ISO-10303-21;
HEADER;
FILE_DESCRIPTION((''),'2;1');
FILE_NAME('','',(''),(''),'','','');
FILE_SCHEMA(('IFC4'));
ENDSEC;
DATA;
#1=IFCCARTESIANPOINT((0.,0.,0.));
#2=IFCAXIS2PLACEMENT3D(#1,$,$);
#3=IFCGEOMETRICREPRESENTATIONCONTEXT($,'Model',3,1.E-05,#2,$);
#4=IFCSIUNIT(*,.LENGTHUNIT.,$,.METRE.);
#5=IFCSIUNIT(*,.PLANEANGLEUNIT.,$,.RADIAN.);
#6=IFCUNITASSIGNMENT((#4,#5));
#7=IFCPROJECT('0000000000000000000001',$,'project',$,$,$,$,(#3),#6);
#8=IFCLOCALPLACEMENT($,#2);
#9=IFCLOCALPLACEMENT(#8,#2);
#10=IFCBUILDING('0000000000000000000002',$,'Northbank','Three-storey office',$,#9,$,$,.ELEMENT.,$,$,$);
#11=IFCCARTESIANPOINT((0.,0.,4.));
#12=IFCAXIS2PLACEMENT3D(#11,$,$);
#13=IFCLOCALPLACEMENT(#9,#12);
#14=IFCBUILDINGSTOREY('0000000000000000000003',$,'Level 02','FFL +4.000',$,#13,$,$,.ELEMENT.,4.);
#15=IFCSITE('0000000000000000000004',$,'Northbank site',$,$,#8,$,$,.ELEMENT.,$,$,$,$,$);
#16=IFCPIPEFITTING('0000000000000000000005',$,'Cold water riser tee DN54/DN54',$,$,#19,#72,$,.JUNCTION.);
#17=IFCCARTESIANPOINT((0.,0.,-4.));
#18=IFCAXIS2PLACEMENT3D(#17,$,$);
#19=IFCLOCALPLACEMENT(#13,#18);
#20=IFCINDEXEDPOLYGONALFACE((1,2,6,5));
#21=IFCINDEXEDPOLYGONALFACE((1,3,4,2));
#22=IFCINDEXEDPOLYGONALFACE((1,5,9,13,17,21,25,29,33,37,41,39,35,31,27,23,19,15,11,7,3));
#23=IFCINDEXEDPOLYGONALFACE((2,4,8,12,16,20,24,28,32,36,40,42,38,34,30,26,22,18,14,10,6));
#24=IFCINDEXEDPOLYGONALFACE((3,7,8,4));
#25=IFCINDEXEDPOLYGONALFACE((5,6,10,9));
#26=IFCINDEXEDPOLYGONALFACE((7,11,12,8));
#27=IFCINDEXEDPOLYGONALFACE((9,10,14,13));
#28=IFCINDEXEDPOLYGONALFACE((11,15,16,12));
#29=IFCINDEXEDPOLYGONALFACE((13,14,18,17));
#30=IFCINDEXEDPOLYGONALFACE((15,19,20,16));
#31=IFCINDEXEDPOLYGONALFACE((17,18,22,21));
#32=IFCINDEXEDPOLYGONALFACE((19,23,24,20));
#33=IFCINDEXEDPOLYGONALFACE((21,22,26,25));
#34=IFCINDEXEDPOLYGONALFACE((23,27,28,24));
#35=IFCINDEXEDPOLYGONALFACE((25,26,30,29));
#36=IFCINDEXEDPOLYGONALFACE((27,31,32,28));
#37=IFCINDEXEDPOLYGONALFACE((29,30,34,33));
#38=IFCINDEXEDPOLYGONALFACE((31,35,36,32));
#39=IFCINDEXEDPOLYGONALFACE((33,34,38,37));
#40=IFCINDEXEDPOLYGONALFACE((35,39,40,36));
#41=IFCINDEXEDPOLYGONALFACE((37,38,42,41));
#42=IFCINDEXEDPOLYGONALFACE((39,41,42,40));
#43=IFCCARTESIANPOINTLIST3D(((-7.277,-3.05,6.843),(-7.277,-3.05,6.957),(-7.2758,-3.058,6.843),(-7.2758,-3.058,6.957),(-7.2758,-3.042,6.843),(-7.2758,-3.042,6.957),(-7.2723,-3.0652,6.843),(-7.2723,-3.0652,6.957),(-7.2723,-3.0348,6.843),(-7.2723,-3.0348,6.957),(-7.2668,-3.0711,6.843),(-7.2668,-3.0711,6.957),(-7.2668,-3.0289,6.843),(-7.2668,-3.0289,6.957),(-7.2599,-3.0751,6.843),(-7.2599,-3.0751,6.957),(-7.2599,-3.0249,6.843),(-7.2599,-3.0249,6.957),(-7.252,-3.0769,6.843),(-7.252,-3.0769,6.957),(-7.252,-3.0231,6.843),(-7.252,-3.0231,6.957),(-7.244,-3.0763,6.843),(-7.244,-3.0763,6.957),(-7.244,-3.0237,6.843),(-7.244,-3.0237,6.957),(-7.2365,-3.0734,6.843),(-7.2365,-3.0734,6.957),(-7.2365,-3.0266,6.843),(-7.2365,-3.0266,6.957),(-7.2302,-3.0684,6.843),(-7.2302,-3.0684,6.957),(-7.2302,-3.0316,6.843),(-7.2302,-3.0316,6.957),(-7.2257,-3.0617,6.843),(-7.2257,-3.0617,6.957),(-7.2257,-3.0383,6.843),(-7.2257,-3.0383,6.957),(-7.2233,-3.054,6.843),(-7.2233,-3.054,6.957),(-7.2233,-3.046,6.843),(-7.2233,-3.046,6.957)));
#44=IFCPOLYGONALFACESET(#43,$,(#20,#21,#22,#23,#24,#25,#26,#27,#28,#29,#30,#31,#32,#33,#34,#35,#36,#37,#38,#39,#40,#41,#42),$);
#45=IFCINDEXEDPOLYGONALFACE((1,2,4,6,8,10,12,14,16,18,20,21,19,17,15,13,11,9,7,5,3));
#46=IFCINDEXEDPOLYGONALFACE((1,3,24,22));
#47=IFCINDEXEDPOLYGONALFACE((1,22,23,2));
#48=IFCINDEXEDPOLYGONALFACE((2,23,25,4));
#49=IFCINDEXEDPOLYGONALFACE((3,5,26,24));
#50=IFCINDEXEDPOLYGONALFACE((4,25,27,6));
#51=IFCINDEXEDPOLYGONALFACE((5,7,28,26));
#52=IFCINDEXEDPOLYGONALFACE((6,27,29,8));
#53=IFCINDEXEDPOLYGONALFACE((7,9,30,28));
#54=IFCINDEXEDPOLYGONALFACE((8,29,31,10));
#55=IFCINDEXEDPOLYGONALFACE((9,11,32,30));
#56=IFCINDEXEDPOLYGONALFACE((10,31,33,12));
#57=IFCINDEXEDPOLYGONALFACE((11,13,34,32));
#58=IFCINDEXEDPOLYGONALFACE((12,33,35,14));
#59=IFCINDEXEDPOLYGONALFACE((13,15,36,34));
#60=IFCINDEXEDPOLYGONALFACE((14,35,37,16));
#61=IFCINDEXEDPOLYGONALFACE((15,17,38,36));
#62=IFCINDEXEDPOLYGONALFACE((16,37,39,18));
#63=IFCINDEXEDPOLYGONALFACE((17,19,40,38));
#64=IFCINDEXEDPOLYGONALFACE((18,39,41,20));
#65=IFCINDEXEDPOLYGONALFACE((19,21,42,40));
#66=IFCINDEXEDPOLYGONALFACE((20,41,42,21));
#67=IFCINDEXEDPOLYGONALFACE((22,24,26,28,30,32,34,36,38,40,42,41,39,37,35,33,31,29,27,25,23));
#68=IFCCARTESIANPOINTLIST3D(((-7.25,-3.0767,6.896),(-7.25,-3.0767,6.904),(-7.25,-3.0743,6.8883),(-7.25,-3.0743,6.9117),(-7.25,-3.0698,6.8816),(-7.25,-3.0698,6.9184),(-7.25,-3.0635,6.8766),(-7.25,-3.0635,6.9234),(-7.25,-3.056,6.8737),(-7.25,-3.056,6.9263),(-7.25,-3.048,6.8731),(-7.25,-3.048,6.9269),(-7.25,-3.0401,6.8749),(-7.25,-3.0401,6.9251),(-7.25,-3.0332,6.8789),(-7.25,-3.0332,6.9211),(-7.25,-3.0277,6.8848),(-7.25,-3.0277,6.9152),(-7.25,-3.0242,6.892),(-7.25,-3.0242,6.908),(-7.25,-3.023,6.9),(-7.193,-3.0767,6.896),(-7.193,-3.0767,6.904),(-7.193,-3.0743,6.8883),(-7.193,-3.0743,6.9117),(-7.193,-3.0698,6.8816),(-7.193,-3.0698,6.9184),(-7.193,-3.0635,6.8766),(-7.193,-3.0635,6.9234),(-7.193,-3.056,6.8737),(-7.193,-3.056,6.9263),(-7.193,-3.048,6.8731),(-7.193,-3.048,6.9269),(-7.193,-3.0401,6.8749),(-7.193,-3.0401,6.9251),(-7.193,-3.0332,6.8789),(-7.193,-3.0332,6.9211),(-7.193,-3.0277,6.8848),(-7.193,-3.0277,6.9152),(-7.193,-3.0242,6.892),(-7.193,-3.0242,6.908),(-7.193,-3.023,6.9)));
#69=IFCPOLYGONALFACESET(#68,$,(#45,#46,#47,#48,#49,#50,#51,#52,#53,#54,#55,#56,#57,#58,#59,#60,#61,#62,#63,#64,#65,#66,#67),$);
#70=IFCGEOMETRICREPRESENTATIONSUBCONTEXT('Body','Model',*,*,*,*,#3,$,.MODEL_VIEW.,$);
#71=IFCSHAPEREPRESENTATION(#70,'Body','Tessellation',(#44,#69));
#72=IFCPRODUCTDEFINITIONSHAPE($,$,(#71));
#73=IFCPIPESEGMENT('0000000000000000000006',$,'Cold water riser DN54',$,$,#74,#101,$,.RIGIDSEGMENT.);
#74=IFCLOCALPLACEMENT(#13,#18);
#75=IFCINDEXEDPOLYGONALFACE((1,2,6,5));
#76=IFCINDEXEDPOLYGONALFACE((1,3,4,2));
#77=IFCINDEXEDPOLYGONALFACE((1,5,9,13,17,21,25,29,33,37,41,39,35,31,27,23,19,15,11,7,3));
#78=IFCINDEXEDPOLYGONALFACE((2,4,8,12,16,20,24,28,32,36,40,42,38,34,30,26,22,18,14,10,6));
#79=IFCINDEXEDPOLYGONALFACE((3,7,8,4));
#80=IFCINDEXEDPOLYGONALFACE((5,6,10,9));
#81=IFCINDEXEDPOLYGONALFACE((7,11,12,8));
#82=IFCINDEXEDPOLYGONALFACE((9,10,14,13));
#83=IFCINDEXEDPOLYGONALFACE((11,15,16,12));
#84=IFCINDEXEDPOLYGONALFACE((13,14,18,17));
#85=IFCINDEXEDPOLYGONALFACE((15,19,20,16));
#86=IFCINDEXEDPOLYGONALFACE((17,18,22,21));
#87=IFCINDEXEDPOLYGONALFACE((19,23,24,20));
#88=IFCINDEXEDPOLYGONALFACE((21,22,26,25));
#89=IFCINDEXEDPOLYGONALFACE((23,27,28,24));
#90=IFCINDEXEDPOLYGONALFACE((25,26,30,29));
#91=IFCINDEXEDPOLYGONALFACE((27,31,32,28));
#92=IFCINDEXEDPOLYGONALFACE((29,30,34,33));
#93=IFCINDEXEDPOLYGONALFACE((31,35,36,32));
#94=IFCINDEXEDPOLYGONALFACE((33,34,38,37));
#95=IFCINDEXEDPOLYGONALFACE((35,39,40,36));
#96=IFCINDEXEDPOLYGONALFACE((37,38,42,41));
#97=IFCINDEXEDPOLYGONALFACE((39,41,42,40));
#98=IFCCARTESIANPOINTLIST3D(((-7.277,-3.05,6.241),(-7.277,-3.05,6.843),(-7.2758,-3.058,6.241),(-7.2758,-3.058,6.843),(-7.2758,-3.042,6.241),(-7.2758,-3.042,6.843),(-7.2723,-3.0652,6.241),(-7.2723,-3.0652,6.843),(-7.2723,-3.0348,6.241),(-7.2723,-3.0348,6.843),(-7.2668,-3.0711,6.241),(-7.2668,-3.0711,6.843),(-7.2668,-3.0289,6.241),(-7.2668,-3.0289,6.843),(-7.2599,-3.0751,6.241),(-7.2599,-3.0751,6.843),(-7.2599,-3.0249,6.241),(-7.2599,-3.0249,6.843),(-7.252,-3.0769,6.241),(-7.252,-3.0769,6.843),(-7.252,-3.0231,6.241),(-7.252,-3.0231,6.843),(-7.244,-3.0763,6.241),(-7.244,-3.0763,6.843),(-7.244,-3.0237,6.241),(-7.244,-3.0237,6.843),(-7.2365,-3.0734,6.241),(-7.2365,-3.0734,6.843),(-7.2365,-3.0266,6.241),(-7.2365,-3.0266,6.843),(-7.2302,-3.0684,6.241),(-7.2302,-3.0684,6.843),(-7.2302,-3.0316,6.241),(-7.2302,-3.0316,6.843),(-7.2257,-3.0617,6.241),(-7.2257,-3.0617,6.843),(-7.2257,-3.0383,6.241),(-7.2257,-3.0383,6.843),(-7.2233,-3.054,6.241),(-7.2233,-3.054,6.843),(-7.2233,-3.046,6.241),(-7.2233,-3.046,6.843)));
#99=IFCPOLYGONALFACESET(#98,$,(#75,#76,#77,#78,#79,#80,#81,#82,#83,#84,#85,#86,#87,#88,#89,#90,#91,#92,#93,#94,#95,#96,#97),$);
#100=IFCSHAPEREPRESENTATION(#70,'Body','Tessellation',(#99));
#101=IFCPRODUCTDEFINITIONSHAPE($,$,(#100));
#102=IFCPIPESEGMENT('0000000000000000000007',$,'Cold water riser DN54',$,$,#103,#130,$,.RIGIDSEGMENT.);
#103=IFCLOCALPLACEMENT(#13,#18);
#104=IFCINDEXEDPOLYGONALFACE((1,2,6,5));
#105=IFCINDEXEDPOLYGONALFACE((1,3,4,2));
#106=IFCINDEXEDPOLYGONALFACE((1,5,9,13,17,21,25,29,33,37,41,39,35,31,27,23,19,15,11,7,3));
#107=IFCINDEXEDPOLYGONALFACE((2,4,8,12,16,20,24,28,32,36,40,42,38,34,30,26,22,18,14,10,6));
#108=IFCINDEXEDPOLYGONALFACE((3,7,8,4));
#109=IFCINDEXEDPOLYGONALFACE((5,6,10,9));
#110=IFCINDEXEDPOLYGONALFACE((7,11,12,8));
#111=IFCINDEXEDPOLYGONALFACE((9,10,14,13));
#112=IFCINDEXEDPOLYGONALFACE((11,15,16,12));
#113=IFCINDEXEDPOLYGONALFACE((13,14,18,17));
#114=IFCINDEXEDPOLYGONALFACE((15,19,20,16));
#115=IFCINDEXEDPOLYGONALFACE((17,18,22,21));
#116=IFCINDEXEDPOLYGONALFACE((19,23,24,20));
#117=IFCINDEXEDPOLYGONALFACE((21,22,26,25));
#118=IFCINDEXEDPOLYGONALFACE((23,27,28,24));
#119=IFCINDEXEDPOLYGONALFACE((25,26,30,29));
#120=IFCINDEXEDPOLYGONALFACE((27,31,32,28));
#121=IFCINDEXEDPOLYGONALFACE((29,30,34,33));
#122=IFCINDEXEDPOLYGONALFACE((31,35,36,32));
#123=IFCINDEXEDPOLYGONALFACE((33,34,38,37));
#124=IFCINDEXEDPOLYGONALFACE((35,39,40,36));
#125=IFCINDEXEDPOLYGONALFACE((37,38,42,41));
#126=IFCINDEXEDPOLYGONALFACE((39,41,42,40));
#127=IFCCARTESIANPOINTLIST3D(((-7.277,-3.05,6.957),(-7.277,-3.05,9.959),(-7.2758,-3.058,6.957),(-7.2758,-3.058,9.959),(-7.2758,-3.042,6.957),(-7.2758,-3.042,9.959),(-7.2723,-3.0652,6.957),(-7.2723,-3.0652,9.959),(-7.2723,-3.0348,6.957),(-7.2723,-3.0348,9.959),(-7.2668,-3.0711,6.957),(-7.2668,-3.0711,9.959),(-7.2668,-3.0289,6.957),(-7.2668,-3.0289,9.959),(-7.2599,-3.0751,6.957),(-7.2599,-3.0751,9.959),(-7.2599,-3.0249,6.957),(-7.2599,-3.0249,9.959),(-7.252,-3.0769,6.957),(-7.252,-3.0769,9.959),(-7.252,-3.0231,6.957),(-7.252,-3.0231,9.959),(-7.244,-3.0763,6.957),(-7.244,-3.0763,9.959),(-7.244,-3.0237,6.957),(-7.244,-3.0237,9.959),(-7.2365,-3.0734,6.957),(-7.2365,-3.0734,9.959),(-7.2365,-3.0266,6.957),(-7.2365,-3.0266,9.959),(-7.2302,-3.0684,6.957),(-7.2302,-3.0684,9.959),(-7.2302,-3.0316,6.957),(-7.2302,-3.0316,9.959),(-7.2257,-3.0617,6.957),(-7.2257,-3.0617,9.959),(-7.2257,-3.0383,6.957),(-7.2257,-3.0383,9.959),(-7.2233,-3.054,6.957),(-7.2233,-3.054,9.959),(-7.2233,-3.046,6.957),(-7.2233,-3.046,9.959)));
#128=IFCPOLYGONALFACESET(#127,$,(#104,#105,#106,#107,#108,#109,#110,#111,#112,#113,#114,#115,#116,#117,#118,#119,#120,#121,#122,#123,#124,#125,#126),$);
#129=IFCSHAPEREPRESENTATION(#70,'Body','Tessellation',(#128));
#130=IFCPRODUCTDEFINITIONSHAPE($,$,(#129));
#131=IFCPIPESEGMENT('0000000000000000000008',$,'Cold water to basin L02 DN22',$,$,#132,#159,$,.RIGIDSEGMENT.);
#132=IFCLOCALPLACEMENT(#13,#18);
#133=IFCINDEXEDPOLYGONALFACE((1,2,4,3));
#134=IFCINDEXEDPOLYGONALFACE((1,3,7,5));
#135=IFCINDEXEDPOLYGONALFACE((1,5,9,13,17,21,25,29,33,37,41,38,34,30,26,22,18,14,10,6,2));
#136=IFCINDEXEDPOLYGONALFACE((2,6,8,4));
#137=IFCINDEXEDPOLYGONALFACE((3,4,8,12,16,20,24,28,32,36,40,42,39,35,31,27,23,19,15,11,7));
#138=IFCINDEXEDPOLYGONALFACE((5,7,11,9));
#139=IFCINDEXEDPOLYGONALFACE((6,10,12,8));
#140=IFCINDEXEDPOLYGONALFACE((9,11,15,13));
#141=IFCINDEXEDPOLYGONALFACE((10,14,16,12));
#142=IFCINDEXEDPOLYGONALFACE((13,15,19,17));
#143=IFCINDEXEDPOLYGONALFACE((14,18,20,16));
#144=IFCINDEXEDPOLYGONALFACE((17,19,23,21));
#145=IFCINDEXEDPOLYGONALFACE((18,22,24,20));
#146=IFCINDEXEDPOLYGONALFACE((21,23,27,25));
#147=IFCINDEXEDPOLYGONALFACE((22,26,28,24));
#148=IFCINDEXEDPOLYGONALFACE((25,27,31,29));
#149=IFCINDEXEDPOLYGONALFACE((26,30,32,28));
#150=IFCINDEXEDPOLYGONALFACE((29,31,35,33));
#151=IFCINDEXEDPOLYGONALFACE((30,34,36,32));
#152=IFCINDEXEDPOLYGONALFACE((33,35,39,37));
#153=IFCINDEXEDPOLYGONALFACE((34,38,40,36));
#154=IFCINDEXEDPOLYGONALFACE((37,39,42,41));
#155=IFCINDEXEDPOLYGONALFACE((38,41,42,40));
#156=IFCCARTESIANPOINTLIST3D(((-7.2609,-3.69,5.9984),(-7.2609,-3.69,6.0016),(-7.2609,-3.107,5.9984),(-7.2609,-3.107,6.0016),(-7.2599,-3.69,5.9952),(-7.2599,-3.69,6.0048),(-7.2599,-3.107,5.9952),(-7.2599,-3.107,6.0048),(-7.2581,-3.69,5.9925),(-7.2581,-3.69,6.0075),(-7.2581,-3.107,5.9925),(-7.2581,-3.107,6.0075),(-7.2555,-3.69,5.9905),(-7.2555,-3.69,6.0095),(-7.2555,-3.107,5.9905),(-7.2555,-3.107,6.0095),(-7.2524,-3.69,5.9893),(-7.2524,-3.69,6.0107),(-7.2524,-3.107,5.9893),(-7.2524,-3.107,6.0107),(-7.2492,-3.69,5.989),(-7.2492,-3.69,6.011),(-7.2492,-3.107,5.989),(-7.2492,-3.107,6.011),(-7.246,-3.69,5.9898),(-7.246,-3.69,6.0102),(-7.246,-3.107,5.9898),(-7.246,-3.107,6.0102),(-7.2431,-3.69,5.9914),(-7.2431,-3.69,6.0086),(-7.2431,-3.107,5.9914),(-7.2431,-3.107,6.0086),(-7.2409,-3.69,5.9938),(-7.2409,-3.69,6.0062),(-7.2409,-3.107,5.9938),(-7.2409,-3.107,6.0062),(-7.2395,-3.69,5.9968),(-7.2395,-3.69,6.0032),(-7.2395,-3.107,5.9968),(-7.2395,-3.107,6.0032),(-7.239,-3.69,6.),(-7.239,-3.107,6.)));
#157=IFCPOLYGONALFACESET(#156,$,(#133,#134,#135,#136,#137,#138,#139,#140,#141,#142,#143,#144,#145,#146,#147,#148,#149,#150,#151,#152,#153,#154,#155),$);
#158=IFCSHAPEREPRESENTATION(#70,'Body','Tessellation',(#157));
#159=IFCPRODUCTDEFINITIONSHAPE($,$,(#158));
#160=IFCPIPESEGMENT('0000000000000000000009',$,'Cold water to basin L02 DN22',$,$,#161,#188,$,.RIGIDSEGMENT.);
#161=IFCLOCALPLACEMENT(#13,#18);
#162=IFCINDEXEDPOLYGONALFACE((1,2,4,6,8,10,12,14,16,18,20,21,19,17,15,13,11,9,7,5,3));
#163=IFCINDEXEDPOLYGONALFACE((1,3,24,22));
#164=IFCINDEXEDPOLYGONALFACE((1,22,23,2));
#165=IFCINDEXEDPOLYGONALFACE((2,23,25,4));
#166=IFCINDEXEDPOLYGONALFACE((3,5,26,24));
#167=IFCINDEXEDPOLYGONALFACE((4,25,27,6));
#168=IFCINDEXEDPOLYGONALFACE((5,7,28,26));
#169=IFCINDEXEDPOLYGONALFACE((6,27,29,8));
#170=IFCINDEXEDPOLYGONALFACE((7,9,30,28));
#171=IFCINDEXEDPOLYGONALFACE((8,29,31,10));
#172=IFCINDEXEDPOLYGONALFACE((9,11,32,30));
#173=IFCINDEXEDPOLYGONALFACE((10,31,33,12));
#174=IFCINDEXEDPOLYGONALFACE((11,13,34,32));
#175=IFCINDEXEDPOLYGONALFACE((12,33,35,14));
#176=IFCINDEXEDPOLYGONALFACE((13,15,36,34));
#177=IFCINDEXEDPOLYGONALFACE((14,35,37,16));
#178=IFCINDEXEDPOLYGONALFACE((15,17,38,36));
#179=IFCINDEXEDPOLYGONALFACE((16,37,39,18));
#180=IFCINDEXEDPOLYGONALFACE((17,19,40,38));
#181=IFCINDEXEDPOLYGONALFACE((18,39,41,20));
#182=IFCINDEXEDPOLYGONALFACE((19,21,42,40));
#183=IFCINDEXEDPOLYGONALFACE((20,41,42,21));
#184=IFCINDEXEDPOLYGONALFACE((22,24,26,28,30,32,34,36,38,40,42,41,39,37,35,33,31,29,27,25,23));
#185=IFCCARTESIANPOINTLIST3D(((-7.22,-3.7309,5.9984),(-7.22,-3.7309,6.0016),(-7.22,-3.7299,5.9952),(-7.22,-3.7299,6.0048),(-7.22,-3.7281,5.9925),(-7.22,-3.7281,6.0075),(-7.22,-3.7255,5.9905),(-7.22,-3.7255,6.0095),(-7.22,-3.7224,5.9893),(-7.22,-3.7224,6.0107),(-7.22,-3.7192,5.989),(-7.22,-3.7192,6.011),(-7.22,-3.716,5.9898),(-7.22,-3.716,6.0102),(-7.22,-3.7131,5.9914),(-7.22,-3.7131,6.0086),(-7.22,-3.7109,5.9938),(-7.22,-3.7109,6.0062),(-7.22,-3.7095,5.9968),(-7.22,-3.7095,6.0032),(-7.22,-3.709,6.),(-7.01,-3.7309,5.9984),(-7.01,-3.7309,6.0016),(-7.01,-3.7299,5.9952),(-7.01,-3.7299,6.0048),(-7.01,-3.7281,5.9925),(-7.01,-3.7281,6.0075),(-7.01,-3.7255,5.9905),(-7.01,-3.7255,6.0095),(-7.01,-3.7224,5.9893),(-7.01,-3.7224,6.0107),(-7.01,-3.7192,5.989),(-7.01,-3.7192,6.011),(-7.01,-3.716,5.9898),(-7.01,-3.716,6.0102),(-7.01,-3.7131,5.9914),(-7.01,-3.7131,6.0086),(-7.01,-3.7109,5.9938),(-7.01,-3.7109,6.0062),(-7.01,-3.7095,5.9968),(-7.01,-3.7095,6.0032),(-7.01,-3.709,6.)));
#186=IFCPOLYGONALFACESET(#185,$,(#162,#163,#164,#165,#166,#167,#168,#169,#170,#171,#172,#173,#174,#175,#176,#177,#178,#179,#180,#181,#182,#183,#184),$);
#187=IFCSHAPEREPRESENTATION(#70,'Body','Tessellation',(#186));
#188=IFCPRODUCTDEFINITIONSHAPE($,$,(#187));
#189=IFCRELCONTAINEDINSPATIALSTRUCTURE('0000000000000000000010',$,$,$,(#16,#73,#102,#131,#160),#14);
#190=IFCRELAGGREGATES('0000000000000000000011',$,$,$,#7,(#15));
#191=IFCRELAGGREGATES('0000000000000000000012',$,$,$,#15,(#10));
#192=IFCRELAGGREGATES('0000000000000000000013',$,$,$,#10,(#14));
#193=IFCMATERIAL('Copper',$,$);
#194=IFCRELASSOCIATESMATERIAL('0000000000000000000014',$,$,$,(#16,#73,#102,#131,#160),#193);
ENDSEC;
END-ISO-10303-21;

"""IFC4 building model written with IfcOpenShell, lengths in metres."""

from ifc_helpers import new_model, si_unit, frame, origin, place, context, subcontext, project, spatial, circle, extrude, material, element, save


model = new_model("IFC4")

# Units and contexts
model_context = context("Model", 3, precision=1e-05, world=origin())
body_context = subcontext(model_context, "Body", "Model", "MODEL_VIEW")
ifc_project = project(units=[si_unit("LENGTHUNIT", "METRE"), si_unit("PLANEANGLEUNIT", "RADIAN")], contexts=[model_context])

# Site, building, storey
site_placement = place(None, origin())
site = spatial("IfcSite", under=ifc_project, at=site_placement, Name="Northbank site", CompositionType="ELEMENT")
building_placement = place(site_placement, origin())
building = spatial("IfcBuilding", under=site, at=building_placement, Name="Northbank", Description="Three-storey office", CompositionType="ELEMENT")
storey_placement = place(building_placement, frame((0.0, 0.0, 4.0)))
storey = spatial("IfcBuildingStorey", under=building, at=storey_placement, Name="Level 02", Description="FFL +4.000", CompositionType="ELEMENT", Elevation=4.0)

# Pipe fitting
ifc_material = material(Name="Copper")
pipe_fitting_1_placement = place(storey_placement, frame((0.0, 0.0, -4.0)))
element("IfcPipeFitting", 1, at=pipe_fitting_1_placement, inside=storey, material=ifc_material, Name="Cold water riser tee DN54/DN54", PredefinedType="JUNCTION", context=body_context, shape_type="SweptSolid", body=[
    extrude(circle(Radius=0.027), frame((-7.25, -3.05, 6.843), z_axis=(0.0, 0.0, 1.0), x_axis=(-1.0, 0.0, 0.0)), (0.0, 0.0, 1.0), 0.114),
    extrude(circle(Radius=0.027), frame((-7.25, -3.05, 6.9), z_axis=(1.0, 0.0, 0.0), x_axis=(0.0, 1.0, 0.0)), (0.0, 0.0, 1.0), 0.057),
])

# Pipe segments
pipe_segment_1_placement = place(storey_placement, frame((0.0, 0.0, -4.0)))
element("IfcPipeSegment", 2, at=pipe_segment_1_placement, inside=storey, material=ifc_material, Name="Cold water riser DN54", PredefinedType="RIGIDSEGMENT", context=body_context, shape_type="SweptSolid", body=[
    extrude(circle(Radius=0.027), frame((-7.25, -3.05, 6.241), z_axis=(0.0, 0.0, 1.0), x_axis=(-1.0, 0.0, 0.0)), (0.0, 0.0, 1.0), 0.602),
])
pipe_segment_2_placement = place(storey_placement, frame((0.0, 0.0, -4.0)))
element("IfcPipeSegment", 3, at=pipe_segment_2_placement, inside=storey, material=ifc_material, Name="Cold water riser DN54", PredefinedType="RIGIDSEGMENT", context=body_context, shape_type="SweptSolid", body=[
    extrude(circle(Radius=0.027), frame((-7.25, -3.05, 6.957), z_axis=(0.0, 0.0, 1.0), x_axis=(-1.0, 0.0, 0.0)), (0.0, 0.0, 1.0), 3.002),
])
pipe_segment_3_placement = place(storey_placement, frame((0.0, 0.0, -4.0)))
element("IfcPipeSegment", 4, at=pipe_segment_3_placement, inside=storey, material=ifc_material, Name="Cold water to basin L02 DN22", PredefinedType="RIGIDSEGMENT", context=body_context, shape_type="SweptSolid", body=[
    extrude(circle(Radius=0.011), frame((-7.25, -3.107, 6.0), z_axis=(0.0, -1.0, 0.0), x_axis=(1.0, 0.0, 0.0)), (0.0, 0.0, 1.0), 0.583),
])
pipe_segment_4_placement = place(storey_placement, frame((0.0, 0.0, -4.0)))
element("IfcPipeSegment", 5, at=pipe_segment_4_placement, inside=storey, material=ifc_material, Name="Cold water to basin L02 DN22", PredefinedType="RIGIDSEGMENT", context=body_context, shape_type="SweptSolid", body=[
    extrude(circle(Radius=0.011), frame((-7.22, -3.72, 6.0), z_axis=(1.0, 0.0, 0.0), x_axis=(0.0, 1.0, 0.0)), (0.0, 0.0, 1.0), 0.21),
])

save(model, "model.ifc")
